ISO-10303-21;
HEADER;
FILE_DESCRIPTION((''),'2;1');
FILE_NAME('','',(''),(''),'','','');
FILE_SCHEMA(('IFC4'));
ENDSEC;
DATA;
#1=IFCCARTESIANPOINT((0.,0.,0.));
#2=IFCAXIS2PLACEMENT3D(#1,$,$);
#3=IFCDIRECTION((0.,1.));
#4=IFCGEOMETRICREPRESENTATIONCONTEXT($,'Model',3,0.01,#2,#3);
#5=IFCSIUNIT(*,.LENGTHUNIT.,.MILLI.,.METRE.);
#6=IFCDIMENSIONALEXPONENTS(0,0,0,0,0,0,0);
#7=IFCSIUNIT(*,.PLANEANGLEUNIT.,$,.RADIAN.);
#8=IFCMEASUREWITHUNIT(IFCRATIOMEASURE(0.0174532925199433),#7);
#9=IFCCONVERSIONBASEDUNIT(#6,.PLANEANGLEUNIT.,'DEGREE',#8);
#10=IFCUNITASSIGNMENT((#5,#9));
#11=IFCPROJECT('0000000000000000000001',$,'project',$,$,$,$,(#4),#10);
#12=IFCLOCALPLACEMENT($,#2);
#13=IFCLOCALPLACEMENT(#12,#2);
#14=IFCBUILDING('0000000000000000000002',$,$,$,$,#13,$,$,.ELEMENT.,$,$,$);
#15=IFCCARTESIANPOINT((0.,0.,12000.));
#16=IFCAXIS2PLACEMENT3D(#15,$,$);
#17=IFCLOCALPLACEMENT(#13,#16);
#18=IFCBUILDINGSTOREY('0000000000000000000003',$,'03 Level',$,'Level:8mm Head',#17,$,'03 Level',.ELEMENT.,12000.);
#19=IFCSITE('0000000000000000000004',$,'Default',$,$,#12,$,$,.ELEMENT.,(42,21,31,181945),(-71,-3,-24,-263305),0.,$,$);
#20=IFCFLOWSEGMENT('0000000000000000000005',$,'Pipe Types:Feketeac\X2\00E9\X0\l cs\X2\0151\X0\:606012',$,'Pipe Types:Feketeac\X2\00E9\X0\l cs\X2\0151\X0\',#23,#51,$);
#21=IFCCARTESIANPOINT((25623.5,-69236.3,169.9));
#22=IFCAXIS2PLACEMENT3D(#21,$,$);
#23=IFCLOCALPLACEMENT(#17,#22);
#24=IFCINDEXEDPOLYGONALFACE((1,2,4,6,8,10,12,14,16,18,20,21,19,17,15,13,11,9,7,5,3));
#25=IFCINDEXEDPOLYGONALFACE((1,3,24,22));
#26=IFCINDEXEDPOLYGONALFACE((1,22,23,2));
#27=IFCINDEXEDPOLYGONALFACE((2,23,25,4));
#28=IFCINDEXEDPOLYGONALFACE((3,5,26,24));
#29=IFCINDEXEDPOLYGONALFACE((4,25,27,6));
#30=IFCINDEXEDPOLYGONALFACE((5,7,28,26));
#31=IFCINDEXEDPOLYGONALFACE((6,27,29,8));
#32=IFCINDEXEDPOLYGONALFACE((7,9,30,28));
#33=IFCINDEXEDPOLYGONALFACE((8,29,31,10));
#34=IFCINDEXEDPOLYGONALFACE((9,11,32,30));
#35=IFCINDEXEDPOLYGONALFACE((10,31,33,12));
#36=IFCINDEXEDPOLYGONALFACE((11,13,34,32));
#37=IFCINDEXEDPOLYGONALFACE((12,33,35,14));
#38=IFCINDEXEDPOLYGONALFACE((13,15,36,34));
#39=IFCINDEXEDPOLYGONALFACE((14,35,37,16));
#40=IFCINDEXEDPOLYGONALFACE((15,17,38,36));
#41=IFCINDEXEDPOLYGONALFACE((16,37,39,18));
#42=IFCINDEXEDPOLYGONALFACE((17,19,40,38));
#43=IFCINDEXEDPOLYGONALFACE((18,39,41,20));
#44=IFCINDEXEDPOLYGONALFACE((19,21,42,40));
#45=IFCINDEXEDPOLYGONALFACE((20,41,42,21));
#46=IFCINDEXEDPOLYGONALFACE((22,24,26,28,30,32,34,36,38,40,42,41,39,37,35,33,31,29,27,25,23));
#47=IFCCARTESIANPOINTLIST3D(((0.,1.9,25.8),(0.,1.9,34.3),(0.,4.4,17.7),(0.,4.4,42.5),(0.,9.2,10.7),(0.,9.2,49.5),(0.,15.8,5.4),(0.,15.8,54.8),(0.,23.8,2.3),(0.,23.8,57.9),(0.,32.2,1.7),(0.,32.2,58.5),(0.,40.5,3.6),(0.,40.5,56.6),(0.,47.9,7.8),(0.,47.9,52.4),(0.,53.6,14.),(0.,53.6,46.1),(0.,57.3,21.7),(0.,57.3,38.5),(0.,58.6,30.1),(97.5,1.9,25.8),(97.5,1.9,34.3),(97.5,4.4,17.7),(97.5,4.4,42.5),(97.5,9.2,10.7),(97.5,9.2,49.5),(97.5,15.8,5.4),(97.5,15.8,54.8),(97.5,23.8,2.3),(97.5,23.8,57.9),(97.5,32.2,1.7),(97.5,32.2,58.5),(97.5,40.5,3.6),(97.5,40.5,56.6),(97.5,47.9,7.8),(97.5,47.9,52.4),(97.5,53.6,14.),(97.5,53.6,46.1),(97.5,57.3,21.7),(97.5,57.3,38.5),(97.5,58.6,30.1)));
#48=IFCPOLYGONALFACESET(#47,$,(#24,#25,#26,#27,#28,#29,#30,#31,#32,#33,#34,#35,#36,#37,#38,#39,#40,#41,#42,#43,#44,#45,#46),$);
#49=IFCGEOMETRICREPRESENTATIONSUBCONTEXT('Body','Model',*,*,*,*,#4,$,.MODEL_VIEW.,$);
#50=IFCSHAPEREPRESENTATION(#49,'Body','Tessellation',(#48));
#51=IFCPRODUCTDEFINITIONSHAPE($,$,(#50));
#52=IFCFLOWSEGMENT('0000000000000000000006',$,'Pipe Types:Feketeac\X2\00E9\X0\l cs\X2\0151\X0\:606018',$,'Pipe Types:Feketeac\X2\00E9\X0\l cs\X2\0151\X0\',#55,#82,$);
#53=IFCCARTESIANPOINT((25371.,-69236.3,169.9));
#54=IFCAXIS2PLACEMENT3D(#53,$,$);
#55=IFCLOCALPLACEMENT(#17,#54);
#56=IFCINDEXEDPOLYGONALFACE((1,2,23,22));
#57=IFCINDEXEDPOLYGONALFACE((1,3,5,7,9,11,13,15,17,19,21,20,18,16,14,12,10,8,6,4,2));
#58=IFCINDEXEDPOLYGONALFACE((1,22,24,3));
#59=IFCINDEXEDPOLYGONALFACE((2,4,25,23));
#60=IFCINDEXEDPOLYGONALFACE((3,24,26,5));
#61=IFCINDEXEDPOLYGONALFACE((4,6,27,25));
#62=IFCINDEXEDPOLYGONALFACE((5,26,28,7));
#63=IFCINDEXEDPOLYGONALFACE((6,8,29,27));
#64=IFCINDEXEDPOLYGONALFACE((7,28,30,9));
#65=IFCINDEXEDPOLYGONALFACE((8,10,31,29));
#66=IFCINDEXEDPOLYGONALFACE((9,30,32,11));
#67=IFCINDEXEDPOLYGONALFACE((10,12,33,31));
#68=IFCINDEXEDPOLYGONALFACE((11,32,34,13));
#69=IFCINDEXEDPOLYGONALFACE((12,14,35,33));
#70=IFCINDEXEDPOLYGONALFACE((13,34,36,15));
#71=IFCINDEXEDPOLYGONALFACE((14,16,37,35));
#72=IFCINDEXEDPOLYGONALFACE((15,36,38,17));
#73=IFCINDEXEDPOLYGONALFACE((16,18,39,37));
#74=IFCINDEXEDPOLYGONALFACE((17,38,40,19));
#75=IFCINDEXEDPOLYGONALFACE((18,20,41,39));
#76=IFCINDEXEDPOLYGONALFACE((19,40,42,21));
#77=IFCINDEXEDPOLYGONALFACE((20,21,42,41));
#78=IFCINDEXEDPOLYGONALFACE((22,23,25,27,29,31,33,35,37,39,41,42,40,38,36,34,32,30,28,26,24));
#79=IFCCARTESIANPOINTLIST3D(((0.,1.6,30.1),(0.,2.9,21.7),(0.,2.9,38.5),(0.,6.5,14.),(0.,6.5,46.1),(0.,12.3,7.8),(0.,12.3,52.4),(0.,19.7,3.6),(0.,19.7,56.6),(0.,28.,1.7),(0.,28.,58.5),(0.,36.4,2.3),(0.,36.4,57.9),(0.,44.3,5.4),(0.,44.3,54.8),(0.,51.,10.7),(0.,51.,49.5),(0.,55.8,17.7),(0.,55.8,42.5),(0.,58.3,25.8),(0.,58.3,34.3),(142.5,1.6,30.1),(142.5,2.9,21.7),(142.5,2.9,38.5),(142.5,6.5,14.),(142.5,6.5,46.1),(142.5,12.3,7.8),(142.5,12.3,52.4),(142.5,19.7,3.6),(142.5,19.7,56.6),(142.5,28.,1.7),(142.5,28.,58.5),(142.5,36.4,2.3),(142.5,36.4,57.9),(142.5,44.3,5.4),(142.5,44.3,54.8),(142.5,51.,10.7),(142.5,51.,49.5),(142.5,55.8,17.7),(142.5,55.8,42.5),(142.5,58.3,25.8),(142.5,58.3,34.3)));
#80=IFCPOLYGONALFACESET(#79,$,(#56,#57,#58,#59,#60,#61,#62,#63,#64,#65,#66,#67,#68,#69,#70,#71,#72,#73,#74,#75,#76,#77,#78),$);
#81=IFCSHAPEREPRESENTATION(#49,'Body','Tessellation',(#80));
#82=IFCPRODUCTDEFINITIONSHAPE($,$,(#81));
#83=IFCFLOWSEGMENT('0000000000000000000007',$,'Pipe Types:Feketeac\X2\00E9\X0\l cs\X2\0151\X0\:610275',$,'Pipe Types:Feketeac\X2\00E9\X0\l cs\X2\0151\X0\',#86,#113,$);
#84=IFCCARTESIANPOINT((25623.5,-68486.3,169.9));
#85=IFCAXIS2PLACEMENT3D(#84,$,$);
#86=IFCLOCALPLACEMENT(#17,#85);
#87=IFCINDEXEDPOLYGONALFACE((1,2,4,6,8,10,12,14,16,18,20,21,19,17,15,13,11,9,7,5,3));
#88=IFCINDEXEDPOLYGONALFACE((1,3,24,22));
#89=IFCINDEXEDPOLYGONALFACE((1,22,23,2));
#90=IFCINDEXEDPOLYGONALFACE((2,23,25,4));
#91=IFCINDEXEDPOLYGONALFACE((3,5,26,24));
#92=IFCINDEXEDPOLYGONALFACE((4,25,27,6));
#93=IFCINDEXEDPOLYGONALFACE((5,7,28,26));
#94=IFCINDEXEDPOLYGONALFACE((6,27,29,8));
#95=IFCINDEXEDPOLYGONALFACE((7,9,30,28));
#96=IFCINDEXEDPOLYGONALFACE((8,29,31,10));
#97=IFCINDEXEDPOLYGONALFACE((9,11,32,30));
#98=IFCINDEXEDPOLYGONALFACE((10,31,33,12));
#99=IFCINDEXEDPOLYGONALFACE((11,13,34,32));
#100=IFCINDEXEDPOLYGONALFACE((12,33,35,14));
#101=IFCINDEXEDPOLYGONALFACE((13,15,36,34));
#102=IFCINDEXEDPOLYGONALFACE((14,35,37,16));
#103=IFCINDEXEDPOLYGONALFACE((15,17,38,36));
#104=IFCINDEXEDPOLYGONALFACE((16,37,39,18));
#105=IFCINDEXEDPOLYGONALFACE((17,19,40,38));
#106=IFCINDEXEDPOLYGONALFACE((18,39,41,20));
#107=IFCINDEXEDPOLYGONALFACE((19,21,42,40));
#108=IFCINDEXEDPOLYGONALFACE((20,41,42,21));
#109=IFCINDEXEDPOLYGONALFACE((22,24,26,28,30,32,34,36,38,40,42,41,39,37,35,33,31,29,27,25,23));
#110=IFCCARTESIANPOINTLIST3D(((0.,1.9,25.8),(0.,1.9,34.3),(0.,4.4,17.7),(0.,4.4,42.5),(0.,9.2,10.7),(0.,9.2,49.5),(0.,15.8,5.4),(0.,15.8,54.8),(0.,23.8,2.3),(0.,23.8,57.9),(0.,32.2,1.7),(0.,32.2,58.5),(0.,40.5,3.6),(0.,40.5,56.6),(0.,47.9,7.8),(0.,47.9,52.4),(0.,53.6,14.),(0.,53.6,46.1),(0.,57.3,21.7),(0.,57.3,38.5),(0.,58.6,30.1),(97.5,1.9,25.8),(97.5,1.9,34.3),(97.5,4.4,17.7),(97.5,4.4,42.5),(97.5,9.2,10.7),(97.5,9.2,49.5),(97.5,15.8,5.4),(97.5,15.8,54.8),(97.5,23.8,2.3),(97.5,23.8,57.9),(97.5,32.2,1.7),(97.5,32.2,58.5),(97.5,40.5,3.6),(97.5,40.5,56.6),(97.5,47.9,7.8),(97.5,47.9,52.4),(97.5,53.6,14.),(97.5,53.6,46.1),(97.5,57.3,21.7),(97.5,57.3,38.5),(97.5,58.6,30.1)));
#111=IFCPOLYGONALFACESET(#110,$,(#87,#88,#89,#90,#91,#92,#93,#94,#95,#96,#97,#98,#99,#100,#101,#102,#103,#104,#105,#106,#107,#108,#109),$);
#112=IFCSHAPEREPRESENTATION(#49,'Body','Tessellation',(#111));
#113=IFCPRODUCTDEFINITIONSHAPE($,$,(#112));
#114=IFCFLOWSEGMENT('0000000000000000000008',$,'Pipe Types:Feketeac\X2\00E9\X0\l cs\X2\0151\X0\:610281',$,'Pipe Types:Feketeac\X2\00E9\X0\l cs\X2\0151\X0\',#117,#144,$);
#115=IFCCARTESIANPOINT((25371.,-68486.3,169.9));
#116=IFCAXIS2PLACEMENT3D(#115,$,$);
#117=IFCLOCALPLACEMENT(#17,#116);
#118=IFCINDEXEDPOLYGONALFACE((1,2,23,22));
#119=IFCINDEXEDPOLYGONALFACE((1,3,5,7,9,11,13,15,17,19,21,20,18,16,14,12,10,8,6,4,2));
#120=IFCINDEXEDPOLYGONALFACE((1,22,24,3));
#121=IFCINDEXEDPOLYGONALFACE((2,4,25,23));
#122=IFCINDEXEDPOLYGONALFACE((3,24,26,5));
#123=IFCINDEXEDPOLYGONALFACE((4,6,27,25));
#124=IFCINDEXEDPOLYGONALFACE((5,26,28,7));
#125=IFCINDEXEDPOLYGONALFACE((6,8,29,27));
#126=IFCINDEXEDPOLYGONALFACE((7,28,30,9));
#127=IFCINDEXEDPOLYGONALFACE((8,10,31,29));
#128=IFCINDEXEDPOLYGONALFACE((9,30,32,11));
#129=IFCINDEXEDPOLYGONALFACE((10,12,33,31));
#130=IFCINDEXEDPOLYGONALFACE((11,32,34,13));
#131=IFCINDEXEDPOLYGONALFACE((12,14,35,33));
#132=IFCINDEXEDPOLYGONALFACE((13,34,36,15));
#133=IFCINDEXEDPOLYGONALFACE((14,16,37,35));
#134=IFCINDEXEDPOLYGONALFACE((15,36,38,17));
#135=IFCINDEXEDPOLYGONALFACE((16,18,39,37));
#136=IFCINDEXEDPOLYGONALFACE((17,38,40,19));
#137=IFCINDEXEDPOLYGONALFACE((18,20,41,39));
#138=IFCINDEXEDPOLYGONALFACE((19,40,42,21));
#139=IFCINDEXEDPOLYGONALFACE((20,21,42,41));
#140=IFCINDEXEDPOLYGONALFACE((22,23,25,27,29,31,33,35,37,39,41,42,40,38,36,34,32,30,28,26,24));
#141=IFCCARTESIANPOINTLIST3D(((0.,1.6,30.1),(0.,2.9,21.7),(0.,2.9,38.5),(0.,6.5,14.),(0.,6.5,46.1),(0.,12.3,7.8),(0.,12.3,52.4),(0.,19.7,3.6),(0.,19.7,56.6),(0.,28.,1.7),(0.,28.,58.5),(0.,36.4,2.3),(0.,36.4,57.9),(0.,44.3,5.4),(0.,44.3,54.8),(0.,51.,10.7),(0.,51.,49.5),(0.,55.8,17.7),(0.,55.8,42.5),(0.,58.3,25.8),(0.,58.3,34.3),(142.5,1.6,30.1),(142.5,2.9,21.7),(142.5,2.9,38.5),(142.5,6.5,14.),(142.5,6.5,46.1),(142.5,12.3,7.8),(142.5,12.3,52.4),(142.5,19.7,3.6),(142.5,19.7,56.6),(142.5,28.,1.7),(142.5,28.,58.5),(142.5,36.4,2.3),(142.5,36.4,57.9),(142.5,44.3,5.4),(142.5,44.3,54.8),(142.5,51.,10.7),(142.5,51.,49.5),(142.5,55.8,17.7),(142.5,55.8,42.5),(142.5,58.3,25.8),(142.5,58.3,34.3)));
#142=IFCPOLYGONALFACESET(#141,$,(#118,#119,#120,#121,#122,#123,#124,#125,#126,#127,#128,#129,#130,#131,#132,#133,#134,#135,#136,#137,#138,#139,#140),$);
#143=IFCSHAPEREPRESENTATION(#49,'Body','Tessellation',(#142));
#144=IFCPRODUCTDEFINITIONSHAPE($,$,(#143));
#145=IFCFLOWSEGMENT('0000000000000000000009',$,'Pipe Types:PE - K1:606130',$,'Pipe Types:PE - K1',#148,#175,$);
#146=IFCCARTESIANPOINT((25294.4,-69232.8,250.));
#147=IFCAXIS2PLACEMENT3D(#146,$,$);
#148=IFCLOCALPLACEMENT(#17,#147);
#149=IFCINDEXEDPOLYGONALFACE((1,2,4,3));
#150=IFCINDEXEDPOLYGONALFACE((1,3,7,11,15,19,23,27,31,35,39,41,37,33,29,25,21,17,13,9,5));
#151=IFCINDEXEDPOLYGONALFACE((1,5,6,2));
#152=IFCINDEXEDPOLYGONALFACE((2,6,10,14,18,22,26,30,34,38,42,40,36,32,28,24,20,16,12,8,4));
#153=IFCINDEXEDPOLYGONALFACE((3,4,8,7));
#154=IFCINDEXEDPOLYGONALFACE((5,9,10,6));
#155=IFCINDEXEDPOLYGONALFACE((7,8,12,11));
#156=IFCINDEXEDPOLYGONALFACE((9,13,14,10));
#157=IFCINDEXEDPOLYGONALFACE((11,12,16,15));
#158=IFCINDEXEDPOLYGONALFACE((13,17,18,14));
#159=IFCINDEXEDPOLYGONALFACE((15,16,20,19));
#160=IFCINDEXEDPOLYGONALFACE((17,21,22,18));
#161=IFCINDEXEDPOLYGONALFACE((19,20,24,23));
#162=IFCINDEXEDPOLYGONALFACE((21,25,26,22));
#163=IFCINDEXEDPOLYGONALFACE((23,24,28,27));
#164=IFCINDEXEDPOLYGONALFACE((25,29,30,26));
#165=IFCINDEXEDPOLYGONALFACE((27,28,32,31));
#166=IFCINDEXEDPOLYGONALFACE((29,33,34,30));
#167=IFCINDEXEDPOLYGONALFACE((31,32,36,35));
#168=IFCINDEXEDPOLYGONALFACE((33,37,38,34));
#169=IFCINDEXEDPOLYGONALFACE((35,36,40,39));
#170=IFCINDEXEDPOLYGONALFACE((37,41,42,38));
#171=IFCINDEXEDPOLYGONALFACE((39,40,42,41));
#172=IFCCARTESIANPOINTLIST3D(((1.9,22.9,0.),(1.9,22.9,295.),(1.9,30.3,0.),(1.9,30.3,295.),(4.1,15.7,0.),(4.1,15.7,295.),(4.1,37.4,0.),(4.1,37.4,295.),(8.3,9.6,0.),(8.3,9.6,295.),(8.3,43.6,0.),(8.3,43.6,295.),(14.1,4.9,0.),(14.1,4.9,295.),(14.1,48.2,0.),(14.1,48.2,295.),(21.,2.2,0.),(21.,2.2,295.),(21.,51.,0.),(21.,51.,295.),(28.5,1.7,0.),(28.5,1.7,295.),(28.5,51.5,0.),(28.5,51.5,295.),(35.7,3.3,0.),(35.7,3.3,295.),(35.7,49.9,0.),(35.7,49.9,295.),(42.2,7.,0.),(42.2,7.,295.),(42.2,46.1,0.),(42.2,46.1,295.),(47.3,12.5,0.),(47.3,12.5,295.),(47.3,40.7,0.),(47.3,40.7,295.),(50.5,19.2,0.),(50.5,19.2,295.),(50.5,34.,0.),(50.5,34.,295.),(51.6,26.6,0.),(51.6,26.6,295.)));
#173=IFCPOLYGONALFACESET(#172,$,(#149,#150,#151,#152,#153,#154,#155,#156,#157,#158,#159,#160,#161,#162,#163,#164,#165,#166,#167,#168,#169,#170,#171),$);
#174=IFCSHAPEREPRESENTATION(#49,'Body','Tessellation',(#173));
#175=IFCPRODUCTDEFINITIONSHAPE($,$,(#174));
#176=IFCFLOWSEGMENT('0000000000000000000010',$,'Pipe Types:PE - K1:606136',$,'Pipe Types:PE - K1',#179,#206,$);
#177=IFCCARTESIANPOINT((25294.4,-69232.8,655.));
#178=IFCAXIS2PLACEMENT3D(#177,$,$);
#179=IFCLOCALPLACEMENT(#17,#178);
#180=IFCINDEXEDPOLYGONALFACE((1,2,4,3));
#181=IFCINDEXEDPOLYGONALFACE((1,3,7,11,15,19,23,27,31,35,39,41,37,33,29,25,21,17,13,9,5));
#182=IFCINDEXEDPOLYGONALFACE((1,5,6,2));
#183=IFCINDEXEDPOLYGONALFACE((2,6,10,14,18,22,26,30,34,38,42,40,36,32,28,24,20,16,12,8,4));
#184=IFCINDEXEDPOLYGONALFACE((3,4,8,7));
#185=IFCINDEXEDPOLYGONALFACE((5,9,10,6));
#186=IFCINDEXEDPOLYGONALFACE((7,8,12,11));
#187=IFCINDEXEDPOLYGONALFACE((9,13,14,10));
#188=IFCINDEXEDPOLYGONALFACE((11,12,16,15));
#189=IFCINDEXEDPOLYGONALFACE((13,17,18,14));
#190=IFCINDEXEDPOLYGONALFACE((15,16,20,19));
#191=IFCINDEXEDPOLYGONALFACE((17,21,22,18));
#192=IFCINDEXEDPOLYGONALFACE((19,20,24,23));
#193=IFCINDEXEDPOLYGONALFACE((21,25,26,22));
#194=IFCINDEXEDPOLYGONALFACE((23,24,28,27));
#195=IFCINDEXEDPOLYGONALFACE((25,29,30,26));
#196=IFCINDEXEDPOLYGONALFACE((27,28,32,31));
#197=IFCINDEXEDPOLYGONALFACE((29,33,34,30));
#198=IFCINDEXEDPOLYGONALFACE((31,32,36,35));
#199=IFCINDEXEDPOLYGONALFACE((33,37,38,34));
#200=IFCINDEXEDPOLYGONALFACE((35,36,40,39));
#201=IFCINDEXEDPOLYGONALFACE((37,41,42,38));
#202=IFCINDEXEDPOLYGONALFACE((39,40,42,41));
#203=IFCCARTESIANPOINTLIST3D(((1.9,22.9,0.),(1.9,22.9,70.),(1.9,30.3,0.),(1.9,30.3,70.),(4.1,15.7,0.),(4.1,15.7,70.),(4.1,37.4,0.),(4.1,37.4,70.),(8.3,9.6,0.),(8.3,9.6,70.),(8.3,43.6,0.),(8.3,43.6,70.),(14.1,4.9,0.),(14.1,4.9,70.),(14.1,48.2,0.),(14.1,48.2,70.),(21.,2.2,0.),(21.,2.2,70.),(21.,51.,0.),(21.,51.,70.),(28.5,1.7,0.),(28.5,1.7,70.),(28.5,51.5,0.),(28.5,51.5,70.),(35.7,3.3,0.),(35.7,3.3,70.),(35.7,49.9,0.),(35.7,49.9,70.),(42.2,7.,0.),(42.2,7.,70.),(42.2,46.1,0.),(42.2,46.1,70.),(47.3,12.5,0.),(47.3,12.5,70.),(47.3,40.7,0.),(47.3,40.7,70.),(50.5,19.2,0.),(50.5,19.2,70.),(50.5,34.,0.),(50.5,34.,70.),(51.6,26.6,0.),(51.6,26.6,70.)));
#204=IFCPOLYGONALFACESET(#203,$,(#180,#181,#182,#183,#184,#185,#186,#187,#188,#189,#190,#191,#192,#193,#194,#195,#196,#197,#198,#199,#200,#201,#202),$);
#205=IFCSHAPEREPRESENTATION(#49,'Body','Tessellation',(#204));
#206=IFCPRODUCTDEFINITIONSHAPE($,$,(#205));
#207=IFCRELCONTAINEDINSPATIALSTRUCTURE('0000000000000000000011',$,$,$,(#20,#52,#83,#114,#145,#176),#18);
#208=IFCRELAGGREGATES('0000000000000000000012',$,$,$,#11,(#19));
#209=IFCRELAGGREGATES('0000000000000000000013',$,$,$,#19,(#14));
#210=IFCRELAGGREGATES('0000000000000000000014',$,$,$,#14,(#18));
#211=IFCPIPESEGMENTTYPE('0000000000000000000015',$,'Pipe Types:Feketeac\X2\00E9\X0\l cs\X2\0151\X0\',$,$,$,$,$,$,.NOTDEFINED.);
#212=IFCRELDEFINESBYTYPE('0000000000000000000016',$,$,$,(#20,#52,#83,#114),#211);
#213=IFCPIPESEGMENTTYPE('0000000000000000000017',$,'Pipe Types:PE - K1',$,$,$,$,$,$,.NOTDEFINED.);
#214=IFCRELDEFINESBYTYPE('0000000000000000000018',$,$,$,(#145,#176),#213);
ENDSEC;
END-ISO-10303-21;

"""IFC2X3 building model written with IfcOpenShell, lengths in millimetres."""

from ifc_helpers import new_model, entity, si_unit, converted_unit, direction, frame, frame_2d, origin, origin_2d_with_axis, place, context, subcontext, project, spatial, circle, extrude, type_object, element, save


model = new_model("IFC2X3")

# Units and contexts
model_context = context("Model", 3, precision=0.01, world=origin(), true_north=direction((0.0, 1.0)))
body_context = subcontext(model_context, "Body", "Model", "MODEL_VIEW")
ifc_project = project(units=[si_unit("LENGTHUNIT", "METRE", prefix="MILLI"), converted_unit("PLANEANGLEUNIT", "DEGREE", entity("IfcRatioMeasure", 0.0174532925199433), si_unit("PLANEANGLEUNIT", "RADIAN"), dimensions=[0, 0, 0, 0, 0, 0, 0])], contexts=[model_context])

# Site, building, storey
site_placement = place(None, origin())
site = spatial("IfcSite", under=ifc_project, at=site_placement, Name="Default", CompositionType="ELEMENT", RefLatitude=(42, 21, 31, 181945), RefLongitude=(-71, -3, -24, -263305), RefElevation=0.0)
building_placement = place(site_placement, origin())
building = spatial("IfcBuilding", under=site, at=building_placement, CompositionType="ELEMENT")
storey_placement = place(building_placement, frame((0.0, 0.0, 12000.0)))
storey = spatial("IfcBuildingStorey", under=building, at=storey_placement, Name="03 Level", ObjectType="Level:8mm Head", LongName="03 Level", CompositionType="ELEMENT", Elevation=12000.0)

# Flow segments
pipe_segment_type_1 = type_object("IfcPipeSegmentType", Name="Pipe Types:Feketeacél cső", PredefinedType="NOTDEFINED")
flow_segment_1_placement = place(storey_placement, frame((25623.5, -69236.3, 169.9)))
element("IfcFlowSegment", 1, at=flow_segment_1_placement, inside=storey, type_object=pipe_segment_type_1, Name="Pipe Types:Feketeacél cső:606012", ObjectType="Pipe Types:Feketeacél cső", context=body_context, shape_type="SweptSolid", body=[
    extrude(circle(Radius=28.5, at=frame_2d((0.0, 0.0), x_axis=(1.0, 0.0))), frame((0.0, 30.1, 30.1), z_axis=(1.0, 0.0, 0.0), x_axis=(0.0, 1.0, 0.0)), (0.0, 0.0, 1.0), 97.5),
])
flow_segment_2_placement = place(storey_placement, frame((25371.0, -69236.3, 169.9)))
element("IfcFlowSegment", 2, at=flow_segment_2_placement, inside=storey, type_object=pipe_segment_type_1, Name="Pipe Types:Feketeacél cső:606018", ObjectType="Pipe Types:Feketeacél cső", context=body_context, shape_type="SweptSolid", body=[
    extrude(circle(Radius=28.5, at=origin_2d_with_axis()), frame((0.0, 30.1, 30.1), z_axis=(1.0, 0.0, 0.0), x_axis=(0.0, -1.0, 0.0)), (0.0, 0.0, 1.0), 142.5),
])
flow_segment_3_placement = place(storey_placement, frame((25623.5, -68486.3, 169.9)))
element("IfcFlowSegment", 3, at=flow_segment_3_placement, inside=storey, type_object=pipe_segment_type_1, Name="Pipe Types:Feketeacél cső:610275", ObjectType="Pipe Types:Feketeacél cső", context=body_context, shape_type="SweptSolid", body=[
    extrude(circle(Radius=28.5, at=frame_2d((0.0, 0.0), x_axis=(1.0, 0.0))), frame((0.0, 30.1, 30.1), z_axis=(1.0, 0.0, 0.0), x_axis=(0.0, 1.0, 0.0)), (0.0, 0.0, 1.0), 97.5),
])
flow_segment_4_placement = place(storey_placement, frame((25371.0, -68486.3, 169.9)))
element("IfcFlowSegment", 4, at=flow_segment_4_placement, inside=storey, type_object=pipe_segment_type_1, Name="Pipe Types:Feketeacél cső:610281", ObjectType="Pipe Types:Feketeacél cső", context=body_context, shape_type="SweptSolid", body=[
    extrude(circle(Radius=28.5, at=origin_2d_with_axis()), frame((0.0, 30.1, 30.1), z_axis=(1.0, 0.0, 0.0), x_axis=(0.0, -1.0, 0.0)), (0.0, 0.0, 1.0), 142.5),
])
pipe_segment_type_2 = type_object("IfcPipeSegmentType", Name="Pipe Types:PE - K1", PredefinedType="NOTDEFINED")
flow_segment_5_placement = place(storey_placement, frame((25294.4, -69232.8, 250.0)))
element("IfcFlowSegment", 5, at=flow_segment_5_placement, inside=storey, type_object=pipe_segment_type_2, Name="Pipe Types:PE - K1:606130", ObjectType="Pipe Types:PE - K1", context=body_context, shape_type="SweptSolid", body=[
    extrude(circle(Radius=25.0, at=frame_2d((0.0, 0.0), x_axis=(1.0, 0.0))), frame((26.6, 26.6, 0.0)), (0.0, 0.0, 1.0), 295.0),
])
flow_segment_6_placement = place(storey_placement, frame((25294.4, -69232.8, 655.0)))
element("IfcFlowSegment", 6, at=flow_segment_6_placement, inside=storey, type_object=pipe_segment_type_2, Name="Pipe Types:PE - K1:606136", ObjectType="Pipe Types:PE - K1", context=body_context, shape_type="SweptSolid", body=[
    extrude(circle(Radius=25.0, at=origin_2d_with_axis()), frame((26.6, 26.6, 0.0)), (0.0, 0.0, 1.0), 70.0),
])

save(model, "model.ifc")
